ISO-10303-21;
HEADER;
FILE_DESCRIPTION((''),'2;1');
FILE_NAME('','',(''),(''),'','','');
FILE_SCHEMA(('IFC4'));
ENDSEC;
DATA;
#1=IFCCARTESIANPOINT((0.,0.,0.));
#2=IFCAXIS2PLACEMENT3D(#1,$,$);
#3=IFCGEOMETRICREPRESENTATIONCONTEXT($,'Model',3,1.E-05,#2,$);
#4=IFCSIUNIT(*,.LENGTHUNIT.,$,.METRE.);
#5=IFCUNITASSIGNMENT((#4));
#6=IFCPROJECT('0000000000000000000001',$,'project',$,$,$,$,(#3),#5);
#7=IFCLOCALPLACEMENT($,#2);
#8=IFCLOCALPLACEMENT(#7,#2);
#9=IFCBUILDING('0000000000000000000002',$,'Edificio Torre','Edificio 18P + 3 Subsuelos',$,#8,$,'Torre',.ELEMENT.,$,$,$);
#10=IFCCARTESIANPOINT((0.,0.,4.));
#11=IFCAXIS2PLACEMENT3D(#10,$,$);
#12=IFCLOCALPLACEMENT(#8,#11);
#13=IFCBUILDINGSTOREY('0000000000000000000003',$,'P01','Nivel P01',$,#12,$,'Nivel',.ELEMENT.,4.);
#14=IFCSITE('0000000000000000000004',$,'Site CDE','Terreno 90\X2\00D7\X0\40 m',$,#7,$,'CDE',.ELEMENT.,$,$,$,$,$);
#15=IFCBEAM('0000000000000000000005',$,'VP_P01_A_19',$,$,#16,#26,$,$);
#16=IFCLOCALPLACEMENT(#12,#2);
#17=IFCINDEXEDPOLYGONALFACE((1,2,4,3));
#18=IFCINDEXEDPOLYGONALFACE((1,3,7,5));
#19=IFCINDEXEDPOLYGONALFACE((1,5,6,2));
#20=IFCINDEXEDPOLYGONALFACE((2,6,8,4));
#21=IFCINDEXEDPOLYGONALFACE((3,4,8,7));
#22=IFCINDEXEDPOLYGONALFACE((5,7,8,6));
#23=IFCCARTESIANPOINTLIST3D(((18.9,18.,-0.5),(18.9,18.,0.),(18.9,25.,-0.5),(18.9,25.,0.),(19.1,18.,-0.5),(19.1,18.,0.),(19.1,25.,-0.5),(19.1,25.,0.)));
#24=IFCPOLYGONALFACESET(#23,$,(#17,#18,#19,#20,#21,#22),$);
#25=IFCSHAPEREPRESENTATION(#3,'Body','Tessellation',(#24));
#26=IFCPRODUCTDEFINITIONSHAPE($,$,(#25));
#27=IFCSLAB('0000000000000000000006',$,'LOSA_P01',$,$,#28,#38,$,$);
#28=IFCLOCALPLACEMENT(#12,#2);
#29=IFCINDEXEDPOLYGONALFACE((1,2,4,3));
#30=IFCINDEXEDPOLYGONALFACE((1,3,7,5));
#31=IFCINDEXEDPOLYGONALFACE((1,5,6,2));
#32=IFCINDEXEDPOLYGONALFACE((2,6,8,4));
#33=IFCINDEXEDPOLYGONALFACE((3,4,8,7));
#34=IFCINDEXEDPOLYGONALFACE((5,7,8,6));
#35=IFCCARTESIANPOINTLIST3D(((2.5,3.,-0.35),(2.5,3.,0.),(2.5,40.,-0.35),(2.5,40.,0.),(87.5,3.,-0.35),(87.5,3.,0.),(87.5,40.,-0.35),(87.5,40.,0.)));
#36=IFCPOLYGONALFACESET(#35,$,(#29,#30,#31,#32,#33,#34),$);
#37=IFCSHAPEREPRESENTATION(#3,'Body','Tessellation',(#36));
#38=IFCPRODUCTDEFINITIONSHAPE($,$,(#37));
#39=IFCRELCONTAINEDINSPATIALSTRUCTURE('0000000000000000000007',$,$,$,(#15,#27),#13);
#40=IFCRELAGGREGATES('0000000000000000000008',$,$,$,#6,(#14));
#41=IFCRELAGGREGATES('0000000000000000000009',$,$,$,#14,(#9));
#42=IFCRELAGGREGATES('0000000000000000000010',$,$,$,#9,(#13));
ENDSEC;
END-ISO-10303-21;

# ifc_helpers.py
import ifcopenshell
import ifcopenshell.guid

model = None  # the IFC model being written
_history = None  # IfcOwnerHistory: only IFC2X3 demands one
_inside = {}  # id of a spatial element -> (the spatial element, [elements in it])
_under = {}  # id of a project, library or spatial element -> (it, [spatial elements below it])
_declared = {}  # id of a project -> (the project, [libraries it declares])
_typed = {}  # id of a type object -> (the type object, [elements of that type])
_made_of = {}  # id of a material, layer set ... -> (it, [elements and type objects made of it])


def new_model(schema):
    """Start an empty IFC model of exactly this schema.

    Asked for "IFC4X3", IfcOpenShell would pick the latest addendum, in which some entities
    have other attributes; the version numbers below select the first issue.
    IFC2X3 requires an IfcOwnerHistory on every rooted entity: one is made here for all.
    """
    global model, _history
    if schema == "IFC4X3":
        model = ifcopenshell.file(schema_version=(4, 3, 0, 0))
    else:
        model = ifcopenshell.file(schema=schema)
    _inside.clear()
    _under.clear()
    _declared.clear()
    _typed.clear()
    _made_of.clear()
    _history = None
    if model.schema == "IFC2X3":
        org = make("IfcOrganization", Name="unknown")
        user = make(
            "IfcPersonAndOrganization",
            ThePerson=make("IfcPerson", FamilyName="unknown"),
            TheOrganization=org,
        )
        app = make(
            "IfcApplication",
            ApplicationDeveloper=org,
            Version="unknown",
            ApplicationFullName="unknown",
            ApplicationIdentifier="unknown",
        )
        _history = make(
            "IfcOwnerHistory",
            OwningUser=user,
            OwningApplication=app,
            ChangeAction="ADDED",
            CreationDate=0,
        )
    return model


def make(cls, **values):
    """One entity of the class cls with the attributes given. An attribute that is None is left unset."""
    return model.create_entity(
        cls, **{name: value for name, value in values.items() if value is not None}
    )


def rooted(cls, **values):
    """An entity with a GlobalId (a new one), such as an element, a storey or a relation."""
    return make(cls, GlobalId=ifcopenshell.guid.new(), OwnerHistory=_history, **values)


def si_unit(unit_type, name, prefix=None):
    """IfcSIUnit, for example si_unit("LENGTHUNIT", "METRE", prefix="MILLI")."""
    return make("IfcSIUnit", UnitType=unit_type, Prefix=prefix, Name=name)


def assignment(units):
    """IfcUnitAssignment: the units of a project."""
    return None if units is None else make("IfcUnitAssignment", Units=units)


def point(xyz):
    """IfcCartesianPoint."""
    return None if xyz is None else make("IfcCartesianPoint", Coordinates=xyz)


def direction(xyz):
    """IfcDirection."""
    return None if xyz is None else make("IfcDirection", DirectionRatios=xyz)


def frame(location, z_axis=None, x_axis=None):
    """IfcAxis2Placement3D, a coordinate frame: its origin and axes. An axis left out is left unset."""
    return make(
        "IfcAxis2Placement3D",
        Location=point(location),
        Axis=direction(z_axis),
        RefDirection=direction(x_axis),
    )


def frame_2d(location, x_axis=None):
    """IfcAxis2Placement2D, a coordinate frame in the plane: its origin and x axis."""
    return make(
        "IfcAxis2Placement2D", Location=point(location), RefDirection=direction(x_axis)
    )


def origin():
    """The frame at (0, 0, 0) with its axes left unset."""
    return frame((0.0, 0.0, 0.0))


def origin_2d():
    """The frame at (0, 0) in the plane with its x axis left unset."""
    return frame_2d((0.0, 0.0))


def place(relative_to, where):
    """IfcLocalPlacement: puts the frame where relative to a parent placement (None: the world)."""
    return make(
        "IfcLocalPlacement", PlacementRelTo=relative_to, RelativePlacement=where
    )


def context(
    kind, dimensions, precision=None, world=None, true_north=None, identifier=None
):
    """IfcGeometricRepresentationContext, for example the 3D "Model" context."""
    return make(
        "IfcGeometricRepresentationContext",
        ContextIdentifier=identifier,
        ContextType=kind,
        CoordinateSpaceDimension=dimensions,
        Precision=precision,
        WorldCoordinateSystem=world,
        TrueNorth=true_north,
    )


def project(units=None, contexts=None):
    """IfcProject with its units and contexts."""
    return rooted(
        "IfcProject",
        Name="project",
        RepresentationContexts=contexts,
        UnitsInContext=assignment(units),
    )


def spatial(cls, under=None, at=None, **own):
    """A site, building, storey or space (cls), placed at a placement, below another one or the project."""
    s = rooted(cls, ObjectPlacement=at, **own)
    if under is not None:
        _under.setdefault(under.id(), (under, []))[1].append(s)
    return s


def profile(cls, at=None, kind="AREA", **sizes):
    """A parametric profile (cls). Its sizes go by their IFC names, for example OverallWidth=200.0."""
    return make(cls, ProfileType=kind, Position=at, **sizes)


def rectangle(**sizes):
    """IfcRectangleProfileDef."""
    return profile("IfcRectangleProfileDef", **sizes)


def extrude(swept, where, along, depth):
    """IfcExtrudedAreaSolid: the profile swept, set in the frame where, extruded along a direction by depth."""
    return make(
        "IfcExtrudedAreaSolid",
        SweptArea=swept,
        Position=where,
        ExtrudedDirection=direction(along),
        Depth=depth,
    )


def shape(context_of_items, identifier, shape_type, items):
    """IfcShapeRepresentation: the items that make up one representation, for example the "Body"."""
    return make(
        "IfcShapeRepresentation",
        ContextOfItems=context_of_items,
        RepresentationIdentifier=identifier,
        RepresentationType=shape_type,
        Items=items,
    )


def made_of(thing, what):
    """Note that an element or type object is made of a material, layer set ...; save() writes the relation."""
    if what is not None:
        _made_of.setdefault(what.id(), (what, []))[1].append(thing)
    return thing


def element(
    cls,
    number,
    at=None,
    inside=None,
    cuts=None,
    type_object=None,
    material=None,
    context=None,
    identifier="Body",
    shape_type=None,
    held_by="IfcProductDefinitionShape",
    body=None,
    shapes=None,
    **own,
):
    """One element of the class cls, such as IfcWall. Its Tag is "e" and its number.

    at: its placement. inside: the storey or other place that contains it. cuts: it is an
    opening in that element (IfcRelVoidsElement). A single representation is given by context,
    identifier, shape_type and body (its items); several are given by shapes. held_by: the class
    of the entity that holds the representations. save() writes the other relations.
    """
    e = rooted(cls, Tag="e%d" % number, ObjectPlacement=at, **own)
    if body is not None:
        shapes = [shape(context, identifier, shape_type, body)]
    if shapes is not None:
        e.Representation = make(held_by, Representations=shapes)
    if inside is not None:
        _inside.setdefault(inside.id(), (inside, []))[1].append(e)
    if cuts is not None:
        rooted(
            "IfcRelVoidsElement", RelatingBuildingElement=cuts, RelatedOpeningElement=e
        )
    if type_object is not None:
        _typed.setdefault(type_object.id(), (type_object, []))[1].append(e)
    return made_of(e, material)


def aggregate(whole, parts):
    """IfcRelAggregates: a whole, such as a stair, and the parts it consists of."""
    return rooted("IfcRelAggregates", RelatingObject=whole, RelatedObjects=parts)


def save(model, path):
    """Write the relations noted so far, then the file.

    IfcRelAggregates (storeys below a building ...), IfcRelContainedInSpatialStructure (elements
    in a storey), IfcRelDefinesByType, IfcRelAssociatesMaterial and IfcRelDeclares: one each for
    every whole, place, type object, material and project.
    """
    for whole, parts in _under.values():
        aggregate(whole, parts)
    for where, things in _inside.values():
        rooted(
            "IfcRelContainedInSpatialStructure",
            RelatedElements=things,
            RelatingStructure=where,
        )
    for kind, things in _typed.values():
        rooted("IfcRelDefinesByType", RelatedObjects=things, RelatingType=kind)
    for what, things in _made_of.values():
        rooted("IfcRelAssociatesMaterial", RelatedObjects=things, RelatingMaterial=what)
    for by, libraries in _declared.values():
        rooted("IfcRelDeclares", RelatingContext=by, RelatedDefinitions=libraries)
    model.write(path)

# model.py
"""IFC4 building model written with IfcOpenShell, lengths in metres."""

from ifc_helpers import new_model, si_unit, frame, origin, origin_2d, place, context, project, spatial, rectangle, extrude, element, save


model = new_model("IFC4")

# Units and contexts
model_context = context("Model", 3, precision=1e-05, world=origin())
ifc_project = project(units=[si_unit("LENGTHUNIT", "METRE")], contexts=[model_context])

# Site, building, storey
site_placement = place(None, origin())
site = spatial("IfcSite", under=ifc_project, at=site_placement, Name="Site CDE", Description="Terreno 90×40 m", LongName="CDE", CompositionType="ELEMENT")
building_placement = place(site_placement, origin())
building = spatial("IfcBuilding", under=site, at=building_placement, Name="Edificio Torre", Description="Edificio 18P + 3 Subsuelos", LongName="Torre", CompositionType="ELEMENT")
storey_placement = place(building_placement, frame((0.0, 0.0, 4.0)))
storey = spatial("IfcBuildingStorey", under=building, at=storey_placement, Name="P01", Description="Nivel P01", LongName="Nivel", CompositionType="ELEMENT", Elevation=4.0)

# Beam
beam_1_placement = place(storey_placement, frame((19.0, 21.5, -0.5)))
element("IfcBeam", 1, at=beam_1_placement, inside=storey, Name="VP_P01_A_19", context=model_context, shape_type="SweptSolid", body=[
    extrude(rectangle(XDim=0.2, YDim=7.0, at=origin_2d()), origin(), (0.0, 0.0, 1.0), 0.5),
])

# Slab
slab_placement = place(storey_placement, frame((45.0, 21.5, -0.35)))
element("IfcSlab", 2, at=slab_placement, inside=storey, Name="LOSA_P01", context=model_context, shape_type="SweptSolid", body=[
    extrude(rectangle(XDim=85.0, YDim=37.0, at=origin_2d()), origin(), (0.0, 0.0, 1.0), 0.35),
])

save(model, "model.ifc")
